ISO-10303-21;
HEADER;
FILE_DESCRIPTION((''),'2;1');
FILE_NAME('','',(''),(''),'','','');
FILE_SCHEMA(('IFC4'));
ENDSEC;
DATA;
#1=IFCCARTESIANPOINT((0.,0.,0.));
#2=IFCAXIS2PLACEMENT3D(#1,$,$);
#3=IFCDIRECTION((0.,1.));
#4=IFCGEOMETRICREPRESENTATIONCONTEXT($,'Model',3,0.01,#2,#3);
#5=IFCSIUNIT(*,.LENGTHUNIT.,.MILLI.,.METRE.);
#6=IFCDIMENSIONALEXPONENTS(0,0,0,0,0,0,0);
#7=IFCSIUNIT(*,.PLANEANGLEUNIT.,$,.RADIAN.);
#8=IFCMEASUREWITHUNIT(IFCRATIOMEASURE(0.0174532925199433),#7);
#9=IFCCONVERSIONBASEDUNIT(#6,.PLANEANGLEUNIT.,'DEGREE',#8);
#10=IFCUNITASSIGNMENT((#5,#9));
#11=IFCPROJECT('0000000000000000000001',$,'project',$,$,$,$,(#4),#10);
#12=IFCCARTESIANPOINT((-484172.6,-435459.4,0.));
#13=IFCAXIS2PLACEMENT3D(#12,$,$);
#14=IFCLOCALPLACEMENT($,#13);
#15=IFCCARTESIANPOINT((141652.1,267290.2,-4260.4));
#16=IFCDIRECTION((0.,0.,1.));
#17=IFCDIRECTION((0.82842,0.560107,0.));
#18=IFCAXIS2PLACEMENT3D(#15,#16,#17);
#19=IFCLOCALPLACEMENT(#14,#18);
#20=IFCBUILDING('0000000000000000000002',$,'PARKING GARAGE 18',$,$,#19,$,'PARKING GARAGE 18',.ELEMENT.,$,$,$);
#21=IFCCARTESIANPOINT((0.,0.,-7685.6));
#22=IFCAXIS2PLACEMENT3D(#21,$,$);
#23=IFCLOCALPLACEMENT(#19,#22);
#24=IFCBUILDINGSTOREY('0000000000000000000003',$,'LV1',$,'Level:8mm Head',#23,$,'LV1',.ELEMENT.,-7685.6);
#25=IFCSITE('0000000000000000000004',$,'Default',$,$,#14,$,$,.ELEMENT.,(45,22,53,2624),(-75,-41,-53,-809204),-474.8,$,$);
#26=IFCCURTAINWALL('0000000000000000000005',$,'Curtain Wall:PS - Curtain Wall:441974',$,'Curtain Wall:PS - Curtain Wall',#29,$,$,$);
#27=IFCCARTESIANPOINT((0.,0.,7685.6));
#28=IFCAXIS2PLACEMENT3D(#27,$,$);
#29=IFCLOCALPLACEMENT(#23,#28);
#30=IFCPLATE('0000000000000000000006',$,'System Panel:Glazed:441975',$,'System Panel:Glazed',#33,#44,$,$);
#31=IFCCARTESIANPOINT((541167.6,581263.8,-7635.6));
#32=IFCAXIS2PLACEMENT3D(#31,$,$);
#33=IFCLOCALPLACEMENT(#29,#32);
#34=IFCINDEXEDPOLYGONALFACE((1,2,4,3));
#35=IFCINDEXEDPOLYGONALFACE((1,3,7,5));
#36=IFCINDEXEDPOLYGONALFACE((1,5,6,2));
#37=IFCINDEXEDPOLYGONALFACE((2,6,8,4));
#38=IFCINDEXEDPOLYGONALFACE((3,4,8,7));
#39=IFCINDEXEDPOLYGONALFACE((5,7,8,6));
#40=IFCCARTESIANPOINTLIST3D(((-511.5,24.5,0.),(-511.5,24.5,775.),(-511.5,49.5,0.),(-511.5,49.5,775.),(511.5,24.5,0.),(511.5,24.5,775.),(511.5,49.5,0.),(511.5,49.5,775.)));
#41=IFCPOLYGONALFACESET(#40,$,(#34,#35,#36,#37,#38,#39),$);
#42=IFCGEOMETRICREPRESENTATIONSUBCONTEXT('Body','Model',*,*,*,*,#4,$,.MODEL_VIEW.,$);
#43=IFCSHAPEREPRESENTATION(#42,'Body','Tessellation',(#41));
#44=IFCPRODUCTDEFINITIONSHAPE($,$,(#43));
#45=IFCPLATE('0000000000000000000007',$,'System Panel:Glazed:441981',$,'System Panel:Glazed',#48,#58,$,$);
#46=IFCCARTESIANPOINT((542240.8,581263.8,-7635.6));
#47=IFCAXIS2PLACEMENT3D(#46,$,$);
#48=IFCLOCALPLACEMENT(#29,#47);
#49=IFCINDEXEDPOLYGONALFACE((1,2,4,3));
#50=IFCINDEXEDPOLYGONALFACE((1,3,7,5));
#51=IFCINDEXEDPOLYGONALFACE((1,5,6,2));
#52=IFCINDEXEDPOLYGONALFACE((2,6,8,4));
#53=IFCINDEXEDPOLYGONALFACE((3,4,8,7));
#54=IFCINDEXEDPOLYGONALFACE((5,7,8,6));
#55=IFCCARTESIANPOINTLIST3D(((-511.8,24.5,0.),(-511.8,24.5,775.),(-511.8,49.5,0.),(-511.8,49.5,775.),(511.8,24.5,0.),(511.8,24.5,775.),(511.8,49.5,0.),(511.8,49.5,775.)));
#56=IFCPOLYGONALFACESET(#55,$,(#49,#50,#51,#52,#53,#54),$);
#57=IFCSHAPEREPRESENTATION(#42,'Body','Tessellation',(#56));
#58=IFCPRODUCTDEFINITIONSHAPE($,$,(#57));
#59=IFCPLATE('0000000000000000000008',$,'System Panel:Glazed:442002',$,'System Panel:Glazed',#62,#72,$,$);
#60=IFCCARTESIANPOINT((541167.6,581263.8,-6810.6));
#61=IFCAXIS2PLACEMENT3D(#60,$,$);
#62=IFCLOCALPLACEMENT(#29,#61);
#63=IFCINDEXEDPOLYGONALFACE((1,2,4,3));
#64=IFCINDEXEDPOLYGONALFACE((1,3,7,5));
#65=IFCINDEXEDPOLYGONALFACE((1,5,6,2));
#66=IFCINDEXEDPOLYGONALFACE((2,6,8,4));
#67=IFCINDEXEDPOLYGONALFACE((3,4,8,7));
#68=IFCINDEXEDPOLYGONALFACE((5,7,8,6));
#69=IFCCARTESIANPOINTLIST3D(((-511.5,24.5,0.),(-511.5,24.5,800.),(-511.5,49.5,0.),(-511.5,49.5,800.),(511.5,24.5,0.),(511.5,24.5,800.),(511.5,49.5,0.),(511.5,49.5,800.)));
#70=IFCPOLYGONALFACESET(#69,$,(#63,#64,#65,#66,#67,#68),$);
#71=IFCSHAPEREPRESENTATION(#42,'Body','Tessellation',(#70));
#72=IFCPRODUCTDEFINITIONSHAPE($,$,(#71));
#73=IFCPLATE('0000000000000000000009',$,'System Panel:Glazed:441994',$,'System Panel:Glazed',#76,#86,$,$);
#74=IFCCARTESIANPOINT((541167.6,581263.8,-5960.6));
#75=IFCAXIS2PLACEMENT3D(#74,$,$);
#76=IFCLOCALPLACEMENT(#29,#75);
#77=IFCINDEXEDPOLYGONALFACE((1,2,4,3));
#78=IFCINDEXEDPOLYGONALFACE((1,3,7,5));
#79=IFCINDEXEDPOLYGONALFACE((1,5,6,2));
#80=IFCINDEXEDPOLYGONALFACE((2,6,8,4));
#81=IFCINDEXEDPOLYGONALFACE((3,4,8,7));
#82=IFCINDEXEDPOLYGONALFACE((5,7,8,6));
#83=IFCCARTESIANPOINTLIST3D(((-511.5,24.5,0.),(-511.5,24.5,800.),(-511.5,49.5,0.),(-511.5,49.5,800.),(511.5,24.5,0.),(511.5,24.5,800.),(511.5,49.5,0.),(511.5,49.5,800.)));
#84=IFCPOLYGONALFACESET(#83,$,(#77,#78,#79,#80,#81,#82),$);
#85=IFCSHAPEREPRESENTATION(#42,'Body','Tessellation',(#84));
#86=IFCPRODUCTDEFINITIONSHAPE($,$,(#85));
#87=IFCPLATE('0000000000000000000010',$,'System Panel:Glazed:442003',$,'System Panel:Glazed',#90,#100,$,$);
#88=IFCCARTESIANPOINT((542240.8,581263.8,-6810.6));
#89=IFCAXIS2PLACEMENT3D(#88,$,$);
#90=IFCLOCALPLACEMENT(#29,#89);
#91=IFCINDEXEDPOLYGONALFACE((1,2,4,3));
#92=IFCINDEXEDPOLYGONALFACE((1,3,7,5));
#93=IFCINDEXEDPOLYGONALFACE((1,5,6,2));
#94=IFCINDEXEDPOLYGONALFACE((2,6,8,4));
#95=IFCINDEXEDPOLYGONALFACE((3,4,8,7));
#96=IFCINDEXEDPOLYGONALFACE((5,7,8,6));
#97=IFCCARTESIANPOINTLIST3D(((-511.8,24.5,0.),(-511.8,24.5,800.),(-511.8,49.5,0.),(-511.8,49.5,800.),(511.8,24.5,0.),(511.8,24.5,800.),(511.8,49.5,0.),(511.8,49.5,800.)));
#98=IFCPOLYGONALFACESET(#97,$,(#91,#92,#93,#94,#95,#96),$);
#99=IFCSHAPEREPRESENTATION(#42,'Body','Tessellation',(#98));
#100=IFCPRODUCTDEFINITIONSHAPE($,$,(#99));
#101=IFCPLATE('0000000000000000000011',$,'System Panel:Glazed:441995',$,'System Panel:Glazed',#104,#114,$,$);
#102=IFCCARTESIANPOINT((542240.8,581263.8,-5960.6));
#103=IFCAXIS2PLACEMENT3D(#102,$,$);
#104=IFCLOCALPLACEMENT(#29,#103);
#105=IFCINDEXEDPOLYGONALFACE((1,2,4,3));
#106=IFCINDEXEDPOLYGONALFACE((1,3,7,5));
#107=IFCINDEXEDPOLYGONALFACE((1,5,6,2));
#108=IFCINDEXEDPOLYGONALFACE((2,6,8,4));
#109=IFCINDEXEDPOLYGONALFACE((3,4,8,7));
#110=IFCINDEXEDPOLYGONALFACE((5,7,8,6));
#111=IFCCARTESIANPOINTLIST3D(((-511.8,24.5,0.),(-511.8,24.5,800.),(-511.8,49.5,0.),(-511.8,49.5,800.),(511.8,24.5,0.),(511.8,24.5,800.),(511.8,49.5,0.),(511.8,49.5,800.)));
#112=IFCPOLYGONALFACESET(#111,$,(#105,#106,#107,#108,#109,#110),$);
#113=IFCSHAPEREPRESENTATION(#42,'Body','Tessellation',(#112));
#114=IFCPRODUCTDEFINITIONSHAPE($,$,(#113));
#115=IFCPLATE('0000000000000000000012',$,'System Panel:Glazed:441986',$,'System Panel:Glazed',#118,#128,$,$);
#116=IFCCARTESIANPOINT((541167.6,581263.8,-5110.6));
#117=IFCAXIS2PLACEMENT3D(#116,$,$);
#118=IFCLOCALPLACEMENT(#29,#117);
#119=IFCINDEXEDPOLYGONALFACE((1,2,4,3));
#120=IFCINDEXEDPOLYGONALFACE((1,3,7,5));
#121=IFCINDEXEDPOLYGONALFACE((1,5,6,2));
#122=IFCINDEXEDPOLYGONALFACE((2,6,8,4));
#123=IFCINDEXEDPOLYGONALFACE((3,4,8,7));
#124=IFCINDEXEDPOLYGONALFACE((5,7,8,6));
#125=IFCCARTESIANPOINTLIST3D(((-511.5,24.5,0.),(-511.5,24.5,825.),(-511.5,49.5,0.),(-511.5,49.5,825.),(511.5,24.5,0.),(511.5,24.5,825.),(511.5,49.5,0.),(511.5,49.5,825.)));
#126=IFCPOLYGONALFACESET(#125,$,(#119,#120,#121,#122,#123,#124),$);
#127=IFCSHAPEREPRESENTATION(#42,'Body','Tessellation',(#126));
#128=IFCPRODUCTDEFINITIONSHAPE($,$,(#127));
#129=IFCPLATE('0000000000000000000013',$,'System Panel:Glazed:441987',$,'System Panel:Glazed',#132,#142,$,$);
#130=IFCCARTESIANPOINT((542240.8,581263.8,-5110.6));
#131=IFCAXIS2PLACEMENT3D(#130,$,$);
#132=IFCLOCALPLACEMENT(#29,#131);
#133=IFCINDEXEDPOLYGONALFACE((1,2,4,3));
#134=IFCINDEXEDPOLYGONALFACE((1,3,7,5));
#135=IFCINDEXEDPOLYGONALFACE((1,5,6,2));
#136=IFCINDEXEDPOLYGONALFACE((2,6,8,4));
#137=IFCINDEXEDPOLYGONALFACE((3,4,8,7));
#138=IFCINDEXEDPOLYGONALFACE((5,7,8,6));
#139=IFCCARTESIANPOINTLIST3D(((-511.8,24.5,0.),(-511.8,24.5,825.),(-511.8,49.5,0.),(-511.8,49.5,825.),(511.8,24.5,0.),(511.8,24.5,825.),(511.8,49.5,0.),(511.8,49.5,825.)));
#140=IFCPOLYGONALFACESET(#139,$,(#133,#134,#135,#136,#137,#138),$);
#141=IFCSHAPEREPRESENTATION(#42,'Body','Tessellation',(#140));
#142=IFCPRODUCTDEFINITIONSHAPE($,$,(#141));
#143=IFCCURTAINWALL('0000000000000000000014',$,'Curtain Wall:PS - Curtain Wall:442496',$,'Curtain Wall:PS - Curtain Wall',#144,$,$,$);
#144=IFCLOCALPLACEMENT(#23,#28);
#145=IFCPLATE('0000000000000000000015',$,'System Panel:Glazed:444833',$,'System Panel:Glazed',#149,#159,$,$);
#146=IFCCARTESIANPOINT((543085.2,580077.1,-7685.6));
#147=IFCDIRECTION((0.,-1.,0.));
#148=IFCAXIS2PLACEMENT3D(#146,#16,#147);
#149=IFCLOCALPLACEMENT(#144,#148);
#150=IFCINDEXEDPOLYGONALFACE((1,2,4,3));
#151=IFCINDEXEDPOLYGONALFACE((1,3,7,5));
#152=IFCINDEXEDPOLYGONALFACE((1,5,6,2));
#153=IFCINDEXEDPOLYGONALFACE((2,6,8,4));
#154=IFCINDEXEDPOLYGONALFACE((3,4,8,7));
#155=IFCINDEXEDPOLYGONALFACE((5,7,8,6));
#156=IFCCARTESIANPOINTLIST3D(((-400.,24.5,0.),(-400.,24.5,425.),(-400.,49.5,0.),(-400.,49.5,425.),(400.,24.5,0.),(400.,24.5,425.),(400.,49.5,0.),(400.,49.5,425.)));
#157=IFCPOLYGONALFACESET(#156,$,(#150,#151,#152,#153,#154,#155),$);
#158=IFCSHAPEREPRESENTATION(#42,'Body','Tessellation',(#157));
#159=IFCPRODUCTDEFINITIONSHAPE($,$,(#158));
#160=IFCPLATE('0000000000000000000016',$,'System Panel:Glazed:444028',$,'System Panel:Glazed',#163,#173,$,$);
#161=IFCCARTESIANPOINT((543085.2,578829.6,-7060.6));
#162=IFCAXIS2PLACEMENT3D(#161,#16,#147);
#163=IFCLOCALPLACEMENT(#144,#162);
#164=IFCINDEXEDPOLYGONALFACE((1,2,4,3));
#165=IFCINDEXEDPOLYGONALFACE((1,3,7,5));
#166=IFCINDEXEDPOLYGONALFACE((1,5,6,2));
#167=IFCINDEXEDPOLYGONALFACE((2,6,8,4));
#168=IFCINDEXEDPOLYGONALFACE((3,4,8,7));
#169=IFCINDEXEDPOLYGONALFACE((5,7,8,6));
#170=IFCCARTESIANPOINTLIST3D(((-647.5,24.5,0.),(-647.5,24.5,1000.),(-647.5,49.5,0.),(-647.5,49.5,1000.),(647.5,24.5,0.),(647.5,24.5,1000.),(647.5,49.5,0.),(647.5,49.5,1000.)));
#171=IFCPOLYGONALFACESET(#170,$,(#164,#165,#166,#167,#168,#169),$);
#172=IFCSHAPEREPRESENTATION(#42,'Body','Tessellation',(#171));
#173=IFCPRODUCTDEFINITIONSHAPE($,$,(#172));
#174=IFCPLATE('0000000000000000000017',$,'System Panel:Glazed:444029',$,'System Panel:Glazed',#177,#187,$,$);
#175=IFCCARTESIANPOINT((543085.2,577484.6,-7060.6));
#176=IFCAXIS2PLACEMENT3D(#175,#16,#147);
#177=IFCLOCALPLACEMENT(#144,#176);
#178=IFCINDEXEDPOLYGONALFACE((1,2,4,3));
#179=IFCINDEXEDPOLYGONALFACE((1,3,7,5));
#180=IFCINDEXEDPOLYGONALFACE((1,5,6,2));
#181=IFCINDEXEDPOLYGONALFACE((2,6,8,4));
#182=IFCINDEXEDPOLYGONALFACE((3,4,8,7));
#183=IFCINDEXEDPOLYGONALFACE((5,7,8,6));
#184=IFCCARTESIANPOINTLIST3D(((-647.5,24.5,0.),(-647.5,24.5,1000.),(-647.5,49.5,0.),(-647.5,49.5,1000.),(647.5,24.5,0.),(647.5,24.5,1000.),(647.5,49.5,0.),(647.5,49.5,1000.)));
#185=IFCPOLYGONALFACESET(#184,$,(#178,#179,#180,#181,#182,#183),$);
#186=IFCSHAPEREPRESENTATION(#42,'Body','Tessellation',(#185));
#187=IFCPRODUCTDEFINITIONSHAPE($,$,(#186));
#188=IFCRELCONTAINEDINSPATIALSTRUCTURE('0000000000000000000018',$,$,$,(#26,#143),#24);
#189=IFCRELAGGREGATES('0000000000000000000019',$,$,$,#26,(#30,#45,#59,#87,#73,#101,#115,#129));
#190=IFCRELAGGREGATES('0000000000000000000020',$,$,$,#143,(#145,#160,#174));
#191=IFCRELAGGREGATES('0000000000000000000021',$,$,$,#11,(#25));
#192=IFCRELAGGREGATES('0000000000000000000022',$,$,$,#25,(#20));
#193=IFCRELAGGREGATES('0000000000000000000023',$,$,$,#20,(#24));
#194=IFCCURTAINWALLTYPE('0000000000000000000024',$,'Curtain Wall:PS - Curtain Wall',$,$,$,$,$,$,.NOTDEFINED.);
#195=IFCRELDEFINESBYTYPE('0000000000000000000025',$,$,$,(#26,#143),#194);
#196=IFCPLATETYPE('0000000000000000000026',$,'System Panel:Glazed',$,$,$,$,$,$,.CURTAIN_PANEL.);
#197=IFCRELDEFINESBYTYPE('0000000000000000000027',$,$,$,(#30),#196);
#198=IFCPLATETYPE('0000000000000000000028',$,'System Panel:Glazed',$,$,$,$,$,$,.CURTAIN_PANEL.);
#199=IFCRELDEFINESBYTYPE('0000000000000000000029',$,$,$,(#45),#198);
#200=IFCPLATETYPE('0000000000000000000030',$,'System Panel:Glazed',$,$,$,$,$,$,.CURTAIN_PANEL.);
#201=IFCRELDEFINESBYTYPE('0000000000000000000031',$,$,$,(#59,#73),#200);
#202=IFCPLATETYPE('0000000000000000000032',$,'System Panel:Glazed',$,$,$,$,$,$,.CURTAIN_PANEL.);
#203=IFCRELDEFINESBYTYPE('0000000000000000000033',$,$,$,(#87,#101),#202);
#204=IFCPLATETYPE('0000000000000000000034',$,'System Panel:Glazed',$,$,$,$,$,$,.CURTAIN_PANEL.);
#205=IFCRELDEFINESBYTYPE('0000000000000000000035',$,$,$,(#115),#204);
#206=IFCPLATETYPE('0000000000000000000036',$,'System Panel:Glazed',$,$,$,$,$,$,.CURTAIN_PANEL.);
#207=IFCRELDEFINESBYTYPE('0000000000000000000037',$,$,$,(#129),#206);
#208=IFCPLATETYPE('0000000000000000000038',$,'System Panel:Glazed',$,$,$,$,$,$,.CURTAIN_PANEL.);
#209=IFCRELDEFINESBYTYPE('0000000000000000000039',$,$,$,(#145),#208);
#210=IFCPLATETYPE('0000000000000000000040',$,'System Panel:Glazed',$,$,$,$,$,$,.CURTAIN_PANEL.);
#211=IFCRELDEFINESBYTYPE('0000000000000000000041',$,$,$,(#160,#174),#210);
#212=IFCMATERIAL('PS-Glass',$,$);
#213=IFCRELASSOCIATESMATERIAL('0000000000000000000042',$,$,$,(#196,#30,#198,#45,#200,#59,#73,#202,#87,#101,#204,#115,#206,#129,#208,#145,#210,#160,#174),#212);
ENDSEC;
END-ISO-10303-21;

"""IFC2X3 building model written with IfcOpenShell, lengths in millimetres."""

from ifc_helpers import new_model, entity, si_unit, converted_unit, direction, frame, origin, origin_2d_with_axis, place, context, subcontext, project, spatial, rectangle, extrude, source, transform, mapped, material, type_object, type_shapes, element, aggregate, save


model = new_model("IFC2X3")

# Units and contexts
model_context = context("Model", 3, precision=0.01, world=origin(), true_north=direction((0.0, 1.0)))
body_context = subcontext(model_context, "Body", "Model", "MODEL_VIEW")
ifc_project = project(units=[si_unit("LENGTHUNIT", "METRE", prefix="MILLI"), converted_unit("PLANEANGLEUNIT", "DEGREE", entity("IfcRatioMeasure", 0.0174532925199433), si_unit("PLANEANGLEUNIT", "RADIAN"), dimensions=[0, 0, 0, 0, 0, 0, 0])], contexts=[model_context])

# Site, building, storey
site_placement = place(None, frame((-484172.6, -435459.4, 0.0)))
site = spatial("IfcSite", under=ifc_project, at=site_placement, Name="Default", CompositionType="ELEMENT", RefLatitude=(45, 22, 53, 2624), RefLongitude=(-75, -41, -53, -809204), RefElevation=-474.8)
building_placement = place(site_placement, frame((141652.1, 267290.2, -4260.4), z_axis=(0.0, 0.0, 1.0), x_axis=(0.82842, 0.560107, 0.0)))
building = spatial("IfcBuilding", under=site, at=building_placement, Name="PARKING GARAGE 18", LongName="PARKING GARAGE 18", CompositionType="ELEMENT")
storey_placement = place(building_placement, frame((0.0, 0.0, -7685.6)))
storey = spatial("IfcBuildingStorey", under=building, at=storey_placement, Name="LV1", ObjectType="Level:8mm Head", LongName="LV1", CompositionType="ELEMENT", Elevation=-7685.6)

# Curtain walls, plates
curtain_wall_type = type_object("IfcCurtainWallType", Name="Curtain Wall:PS - Curtain Wall", PredefinedType="NOTDEFINED")
curtain_wall_1_placement = place(storey_placement, frame((0.0, 0.0, 7685.6)))
curtain_wall_1 = element("IfcCurtainWall", 1, at=curtain_wall_1_placement, inside=storey, type_object=curtain_wall_type, Name="Curtain Wall:PS - Curtain Wall:441974", ObjectType="Curtain Wall:PS - Curtain Wall")
ifc_material_1 = material(Name="PS-Glass")
plate_type_1 = type_object("IfcPlateType", Name="System Panel:Glazed", PredefinedType="CURTAIN_PANEL", material=ifc_material_1)
shared_shape_1 = source(origin(), body_context, "Body", "SweptSolid", [
    extrude(rectangle(XDim=25.0, YDim=1023.0, at=origin_2d_with_axis()), frame((0.0, 37.0, 0.0), z_axis=(0.0, 0.0, 1.0), x_axis=(0.0, 1.0, 0.0)), (0.0, 0.0, 1.0), 775.0),
])
type_shapes(plate_type_1, [shared_shape_1])
plate_1_placement = place(curtain_wall_1_placement, frame((541167.6, 581263.8, -7635.6)))
plate_1 = element("IfcPlate", 2, at=plate_1_placement, type_object=plate_type_1, material=ifc_material_1, Name="System Panel:Glazed:441975", ObjectType="System Panel:Glazed", context=body_context, shape_type="MappedRepresentation", body=[
    mapped(shared_shape_1, transform((0.0, 0.0, 0.0), scale=1.0)),
])
plate_type_2 = type_object("IfcPlateType", Name="System Panel:Glazed", PredefinedType="CURTAIN_PANEL", material=ifc_material_1)
shared_shape_2 = source(origin(), body_context, "Body", "SweptSolid", [
    extrude(rectangle(XDim=25.0, YDim=1023.5, at=origin_2d_with_axis()), frame((0.0, 37.0, 0.0), z_axis=(0.0, 0.0, 1.0), x_axis=(0.0, 1.0, 0.0)), (0.0, 0.0, 1.0), 775.0),
])
type_shapes(plate_type_2, [shared_shape_2])
plate_2_placement = place(curtain_wall_1_placement, frame((542240.8, 581263.8, -7635.6)))
plate_2 = element("IfcPlate", 3, at=plate_2_placement, type_object=plate_type_2, material=ifc_material_1, Name="System Panel:Glazed:441981", ObjectType="System Panel:Glazed", context=body_context, shape_type="MappedRepresentation", body=[
    mapped(shared_shape_2, transform((0.0, 0.0, 0.0), scale=1.0)),
])
plate_type_3 = type_object("IfcPlateType", Name="System Panel:Glazed", PredefinedType="CURTAIN_PANEL", material=ifc_material_1)
shared_shape_3 = source(origin(), body_context, "Body", "SweptSolid", [
    extrude(rectangle(XDim=25.0, YDim=1023.0, at=origin_2d_with_axis()), frame((0.0, 37.0, 0.0), z_axis=(0.0, 0.0, 1.0), x_axis=(0.0, 1.0, 0.0)), (0.0, 0.0, 1.0), 800.0),
])
type_shapes(plate_type_3, [shared_shape_3])
plate_3_placement = place(curtain_wall_1_placement, frame((541167.6, 581263.8, -6810.6)))
plate_3 = element("IfcPlate", 4, at=plate_3_placement, type_object=plate_type_3, material=ifc_material_1, Name="System Panel:Glazed:442002", ObjectType="System Panel:Glazed", context=body_context, shape_type="MappedRepresentation", body=[
    mapped(shared_shape_3, transform((0.0, 0.0, 0.0), scale=1.0)),
])
plate_4_placement = place(curtain_wall_1_placement, frame((541167.6, 581263.8, -5960.6)))
plate_4 = element("IfcPlate", 5, at=plate_4_placement, type_object=plate_type_3, material=ifc_material_1, Name="System Panel:Glazed:441994", ObjectType="System Panel:Glazed", context=body_context, shape_type="MappedRepresentation", body=[
    mapped(shared_shape_3, transform((0.0, 0.0, 0.0), scale=1.0)),
])
plate_type_4 = type_object("IfcPlateType", Name="System Panel:Glazed", PredefinedType="CURTAIN_PANEL", material=ifc_material_1)
shared_shape_4 = source(origin(), body_context, "Body", "SweptSolid", [
    extrude(rectangle(XDim=25.0, YDim=1023.5, at=origin_2d_with_axis()), frame((0.0, 37.0, 0.0), z_axis=(0.0, 0.0, 1.0), x_axis=(0.0, 1.0, 0.0)), (0.0, 0.0, 1.0), 800.0),
])
type_shapes(plate_type_4, [shared_shape_4])
plate_5_placement = place(curtain_wall_1_placement, frame((542240.8, 581263.8, -6810.6)))
plate_5 = element("IfcPlate", 6, at=plate_5_placement, type_object=plate_type_4, material=ifc_material_1, Name="System Panel:Glazed:442003", ObjectType="System Panel:Glazed", context=body_context, shape_type="MappedRepresentation", body=[
    mapped(shared_shape_4, transform((0.0, 0.0, 0.0), scale=1.0)),
])
plate_6_placement = place(curtain_wall_1_placement, frame((542240.8, 581263.8, -5960.6)))
plate_6 = element("IfcPlate", 7, at=plate_6_placement, type_object=plate_type_4, material=ifc_material_1, Name="System Panel:Glazed:441995", ObjectType="System Panel:Glazed", context=body_context, shape_type="MappedRepresentation", body=[
    mapped(shared_shape_4, transform((0.0, 0.0, 0.0), scale=1.0)),
])
plate_type_5 = type_object("IfcPlateType", Name="System Panel:Glazed", PredefinedType="CURTAIN_PANEL", material=ifc_material_1)
shared_shape_5 = source(origin(), body_context, "Body", "SweptSolid", [
    extrude(rectangle(XDim=25.0, YDim=1023.0, at=origin_2d_with_axis()), frame((0.0, 37.0, 0.0), z_axis=(0.0, 0.0, 1.0), x_axis=(0.0, 1.0, 0.0)), (0.0, 0.0, 1.0), 825.0),
])
type_shapes(plate_type_5, [shared_shape_5])
plate_7_placement = place(curtain_wall_1_placement, frame((541167.6, 581263.8, -5110.6)))
plate_7 = element("IfcPlate", 8, at=plate_7_placement, type_object=plate_type_5, material=ifc_material_1, Name="System Panel:Glazed:441986", ObjectType="System Panel:Glazed", context=body_context, shape_type="MappedRepresentation", body=[
    mapped(shared_shape_5, transform((0.0, 0.0, 0.0), scale=1.0)),
])
plate_type_6 = type_object("IfcPlateType", Name="System Panel:Glazed", PredefinedType="CURTAIN_PANEL", material=ifc_material_1)
shared_shape_6 = source(origin(), body_context, "Body", "SweptSolid", [
    extrude(rectangle(XDim=25.0, YDim=1023.5, at=origin_2d_with_axis()), frame((0.0, 37.0, 0.0), z_axis=(0.0, 0.0, 1.0), x_axis=(0.0, 1.0, 0.0)), (0.0, 0.0, 1.0), 825.0),
])
type_shapes(plate_type_6, [shared_shape_6])
plate_8_placement = place(curtain_wall_1_placement, frame((542240.8, 581263.8, -5110.6)))
plate_8 = element("IfcPlate", 9, at=plate_8_placement, type_object=plate_type_6, material=ifc_material_1, Name="System Panel:Glazed:441987", ObjectType="System Panel:Glazed", context=body_context, shape_type="MappedRepresentation", body=[
    mapped(shared_shape_6, transform((0.0, 0.0, 0.0), scale=1.0)),
])
aggregate(curtain_wall_1, [plate_1, plate_2, plate_3, plate_5, plate_4, plate_6, plate_7, plate_8])
curtain_wall_2_placement = place(storey_placement, frame((0.0, 0.0, 7685.6)))
curtain_wall_2 = element("IfcCurtainWall", 10, at=curtain_wall_2_placement, inside=storey, type_object=curtain_wall_type, Name="Curtain Wall:PS - Curtain Wall:442496", ObjectType="Curtain Wall:PS - Curtain Wall")
plate_type_7 = type_object("IfcPlateType", Name="System Panel:Glazed", PredefinedType="CURTAIN_PANEL", material=ifc_material_1)
shared_shape_7 = source(origin(), body_context, "Body", "SweptSolid", [
    extrude(rectangle(XDim=25.0, YDim=800.0, at=origin_2d_with_axis()), frame((0.0, 37.0, 0.0), z_axis=(0.0, 0.0, 1.0), x_axis=(0.0, 1.0, 0.0)), (0.0, 0.0, 1.0), 425.0),
])
type_shapes(plate_type_7, [shared_shape_7])
plate_9_placement = place(curtain_wall_2_placement, frame((543085.2, 580077.1, -7685.6), z_axis=(0.0, 0.0, 1.0), x_axis=(0.0, -1.0, 0.0)))
plate_9 = element("IfcPlate", 11, at=plate_9_placement, type_object=plate_type_7, material=ifc_material_1, Name="System Panel:Glazed:444833", ObjectType="System Panel:Glazed", context=body_context, shape_type="MappedRepresentation", body=[
    mapped(shared_shape_7, transform((0.0, 0.0, 0.0), scale=1.0)),
])
plate_type_8 = type_object("IfcPlateType", Name="System Panel:Glazed", PredefinedType="CURTAIN_PANEL", material=ifc_material_1)
shared_shape_8 = source(origin(), body_context, "Body", "SweptSolid", [
    extrude(rectangle(XDim=25.0, YDim=1295.0, at=origin_2d_with_axis()), frame((0.0, 37.0, 0.0), z_axis=(0.0, 0.0, 1.0), x_axis=(0.0, 1.0, 0.0)), (0.0, 0.0, 1.0), 1000.0),
])
type_shapes(plate_type_8, [shared_shape_8])
plate_10_placement = place(curtain_wall_2_placement, frame((543085.2, 578829.6, -7060.6), z_axis=(0.0, 0.0, 1.0), x_axis=(0.0, -1.0, 0.0)))
plate_10 = element("IfcPlate", 12, at=plate_10_placement, type_object=plate_type_8, material=ifc_material_1, Name="System Panel:Glazed:444028", ObjectType="System Panel:Glazed", context=body_context, shape_type="MappedRepresentation", body=[
    mapped(shared_shape_8, transform((0.0, 0.0, 0.0), scale=1.0)),
])
plate_11_placement = place(curtain_wall_2_placement, frame((543085.2, 577484.6, -7060.6), z_axis=(0.0, 0.0, 1.0), x_axis=(0.0, -1.0, 0.0)))
plate_11 = element("IfcPlate", 13, at=plate_11_placement, type_object=plate_type_8, material=ifc_material_1, Name="System Panel:Glazed:444029", ObjectType="System Panel:Glazed", context=body_context, shape_type="MappedRepresentation", body=[
    mapped(shared_shape_8, transform((0.0, 0.0, 0.0), scale=1.0)),
])
aggregate(curtain_wall_2, [plate_9, plate_10, plate_11])

save(model, "model.ifc")
